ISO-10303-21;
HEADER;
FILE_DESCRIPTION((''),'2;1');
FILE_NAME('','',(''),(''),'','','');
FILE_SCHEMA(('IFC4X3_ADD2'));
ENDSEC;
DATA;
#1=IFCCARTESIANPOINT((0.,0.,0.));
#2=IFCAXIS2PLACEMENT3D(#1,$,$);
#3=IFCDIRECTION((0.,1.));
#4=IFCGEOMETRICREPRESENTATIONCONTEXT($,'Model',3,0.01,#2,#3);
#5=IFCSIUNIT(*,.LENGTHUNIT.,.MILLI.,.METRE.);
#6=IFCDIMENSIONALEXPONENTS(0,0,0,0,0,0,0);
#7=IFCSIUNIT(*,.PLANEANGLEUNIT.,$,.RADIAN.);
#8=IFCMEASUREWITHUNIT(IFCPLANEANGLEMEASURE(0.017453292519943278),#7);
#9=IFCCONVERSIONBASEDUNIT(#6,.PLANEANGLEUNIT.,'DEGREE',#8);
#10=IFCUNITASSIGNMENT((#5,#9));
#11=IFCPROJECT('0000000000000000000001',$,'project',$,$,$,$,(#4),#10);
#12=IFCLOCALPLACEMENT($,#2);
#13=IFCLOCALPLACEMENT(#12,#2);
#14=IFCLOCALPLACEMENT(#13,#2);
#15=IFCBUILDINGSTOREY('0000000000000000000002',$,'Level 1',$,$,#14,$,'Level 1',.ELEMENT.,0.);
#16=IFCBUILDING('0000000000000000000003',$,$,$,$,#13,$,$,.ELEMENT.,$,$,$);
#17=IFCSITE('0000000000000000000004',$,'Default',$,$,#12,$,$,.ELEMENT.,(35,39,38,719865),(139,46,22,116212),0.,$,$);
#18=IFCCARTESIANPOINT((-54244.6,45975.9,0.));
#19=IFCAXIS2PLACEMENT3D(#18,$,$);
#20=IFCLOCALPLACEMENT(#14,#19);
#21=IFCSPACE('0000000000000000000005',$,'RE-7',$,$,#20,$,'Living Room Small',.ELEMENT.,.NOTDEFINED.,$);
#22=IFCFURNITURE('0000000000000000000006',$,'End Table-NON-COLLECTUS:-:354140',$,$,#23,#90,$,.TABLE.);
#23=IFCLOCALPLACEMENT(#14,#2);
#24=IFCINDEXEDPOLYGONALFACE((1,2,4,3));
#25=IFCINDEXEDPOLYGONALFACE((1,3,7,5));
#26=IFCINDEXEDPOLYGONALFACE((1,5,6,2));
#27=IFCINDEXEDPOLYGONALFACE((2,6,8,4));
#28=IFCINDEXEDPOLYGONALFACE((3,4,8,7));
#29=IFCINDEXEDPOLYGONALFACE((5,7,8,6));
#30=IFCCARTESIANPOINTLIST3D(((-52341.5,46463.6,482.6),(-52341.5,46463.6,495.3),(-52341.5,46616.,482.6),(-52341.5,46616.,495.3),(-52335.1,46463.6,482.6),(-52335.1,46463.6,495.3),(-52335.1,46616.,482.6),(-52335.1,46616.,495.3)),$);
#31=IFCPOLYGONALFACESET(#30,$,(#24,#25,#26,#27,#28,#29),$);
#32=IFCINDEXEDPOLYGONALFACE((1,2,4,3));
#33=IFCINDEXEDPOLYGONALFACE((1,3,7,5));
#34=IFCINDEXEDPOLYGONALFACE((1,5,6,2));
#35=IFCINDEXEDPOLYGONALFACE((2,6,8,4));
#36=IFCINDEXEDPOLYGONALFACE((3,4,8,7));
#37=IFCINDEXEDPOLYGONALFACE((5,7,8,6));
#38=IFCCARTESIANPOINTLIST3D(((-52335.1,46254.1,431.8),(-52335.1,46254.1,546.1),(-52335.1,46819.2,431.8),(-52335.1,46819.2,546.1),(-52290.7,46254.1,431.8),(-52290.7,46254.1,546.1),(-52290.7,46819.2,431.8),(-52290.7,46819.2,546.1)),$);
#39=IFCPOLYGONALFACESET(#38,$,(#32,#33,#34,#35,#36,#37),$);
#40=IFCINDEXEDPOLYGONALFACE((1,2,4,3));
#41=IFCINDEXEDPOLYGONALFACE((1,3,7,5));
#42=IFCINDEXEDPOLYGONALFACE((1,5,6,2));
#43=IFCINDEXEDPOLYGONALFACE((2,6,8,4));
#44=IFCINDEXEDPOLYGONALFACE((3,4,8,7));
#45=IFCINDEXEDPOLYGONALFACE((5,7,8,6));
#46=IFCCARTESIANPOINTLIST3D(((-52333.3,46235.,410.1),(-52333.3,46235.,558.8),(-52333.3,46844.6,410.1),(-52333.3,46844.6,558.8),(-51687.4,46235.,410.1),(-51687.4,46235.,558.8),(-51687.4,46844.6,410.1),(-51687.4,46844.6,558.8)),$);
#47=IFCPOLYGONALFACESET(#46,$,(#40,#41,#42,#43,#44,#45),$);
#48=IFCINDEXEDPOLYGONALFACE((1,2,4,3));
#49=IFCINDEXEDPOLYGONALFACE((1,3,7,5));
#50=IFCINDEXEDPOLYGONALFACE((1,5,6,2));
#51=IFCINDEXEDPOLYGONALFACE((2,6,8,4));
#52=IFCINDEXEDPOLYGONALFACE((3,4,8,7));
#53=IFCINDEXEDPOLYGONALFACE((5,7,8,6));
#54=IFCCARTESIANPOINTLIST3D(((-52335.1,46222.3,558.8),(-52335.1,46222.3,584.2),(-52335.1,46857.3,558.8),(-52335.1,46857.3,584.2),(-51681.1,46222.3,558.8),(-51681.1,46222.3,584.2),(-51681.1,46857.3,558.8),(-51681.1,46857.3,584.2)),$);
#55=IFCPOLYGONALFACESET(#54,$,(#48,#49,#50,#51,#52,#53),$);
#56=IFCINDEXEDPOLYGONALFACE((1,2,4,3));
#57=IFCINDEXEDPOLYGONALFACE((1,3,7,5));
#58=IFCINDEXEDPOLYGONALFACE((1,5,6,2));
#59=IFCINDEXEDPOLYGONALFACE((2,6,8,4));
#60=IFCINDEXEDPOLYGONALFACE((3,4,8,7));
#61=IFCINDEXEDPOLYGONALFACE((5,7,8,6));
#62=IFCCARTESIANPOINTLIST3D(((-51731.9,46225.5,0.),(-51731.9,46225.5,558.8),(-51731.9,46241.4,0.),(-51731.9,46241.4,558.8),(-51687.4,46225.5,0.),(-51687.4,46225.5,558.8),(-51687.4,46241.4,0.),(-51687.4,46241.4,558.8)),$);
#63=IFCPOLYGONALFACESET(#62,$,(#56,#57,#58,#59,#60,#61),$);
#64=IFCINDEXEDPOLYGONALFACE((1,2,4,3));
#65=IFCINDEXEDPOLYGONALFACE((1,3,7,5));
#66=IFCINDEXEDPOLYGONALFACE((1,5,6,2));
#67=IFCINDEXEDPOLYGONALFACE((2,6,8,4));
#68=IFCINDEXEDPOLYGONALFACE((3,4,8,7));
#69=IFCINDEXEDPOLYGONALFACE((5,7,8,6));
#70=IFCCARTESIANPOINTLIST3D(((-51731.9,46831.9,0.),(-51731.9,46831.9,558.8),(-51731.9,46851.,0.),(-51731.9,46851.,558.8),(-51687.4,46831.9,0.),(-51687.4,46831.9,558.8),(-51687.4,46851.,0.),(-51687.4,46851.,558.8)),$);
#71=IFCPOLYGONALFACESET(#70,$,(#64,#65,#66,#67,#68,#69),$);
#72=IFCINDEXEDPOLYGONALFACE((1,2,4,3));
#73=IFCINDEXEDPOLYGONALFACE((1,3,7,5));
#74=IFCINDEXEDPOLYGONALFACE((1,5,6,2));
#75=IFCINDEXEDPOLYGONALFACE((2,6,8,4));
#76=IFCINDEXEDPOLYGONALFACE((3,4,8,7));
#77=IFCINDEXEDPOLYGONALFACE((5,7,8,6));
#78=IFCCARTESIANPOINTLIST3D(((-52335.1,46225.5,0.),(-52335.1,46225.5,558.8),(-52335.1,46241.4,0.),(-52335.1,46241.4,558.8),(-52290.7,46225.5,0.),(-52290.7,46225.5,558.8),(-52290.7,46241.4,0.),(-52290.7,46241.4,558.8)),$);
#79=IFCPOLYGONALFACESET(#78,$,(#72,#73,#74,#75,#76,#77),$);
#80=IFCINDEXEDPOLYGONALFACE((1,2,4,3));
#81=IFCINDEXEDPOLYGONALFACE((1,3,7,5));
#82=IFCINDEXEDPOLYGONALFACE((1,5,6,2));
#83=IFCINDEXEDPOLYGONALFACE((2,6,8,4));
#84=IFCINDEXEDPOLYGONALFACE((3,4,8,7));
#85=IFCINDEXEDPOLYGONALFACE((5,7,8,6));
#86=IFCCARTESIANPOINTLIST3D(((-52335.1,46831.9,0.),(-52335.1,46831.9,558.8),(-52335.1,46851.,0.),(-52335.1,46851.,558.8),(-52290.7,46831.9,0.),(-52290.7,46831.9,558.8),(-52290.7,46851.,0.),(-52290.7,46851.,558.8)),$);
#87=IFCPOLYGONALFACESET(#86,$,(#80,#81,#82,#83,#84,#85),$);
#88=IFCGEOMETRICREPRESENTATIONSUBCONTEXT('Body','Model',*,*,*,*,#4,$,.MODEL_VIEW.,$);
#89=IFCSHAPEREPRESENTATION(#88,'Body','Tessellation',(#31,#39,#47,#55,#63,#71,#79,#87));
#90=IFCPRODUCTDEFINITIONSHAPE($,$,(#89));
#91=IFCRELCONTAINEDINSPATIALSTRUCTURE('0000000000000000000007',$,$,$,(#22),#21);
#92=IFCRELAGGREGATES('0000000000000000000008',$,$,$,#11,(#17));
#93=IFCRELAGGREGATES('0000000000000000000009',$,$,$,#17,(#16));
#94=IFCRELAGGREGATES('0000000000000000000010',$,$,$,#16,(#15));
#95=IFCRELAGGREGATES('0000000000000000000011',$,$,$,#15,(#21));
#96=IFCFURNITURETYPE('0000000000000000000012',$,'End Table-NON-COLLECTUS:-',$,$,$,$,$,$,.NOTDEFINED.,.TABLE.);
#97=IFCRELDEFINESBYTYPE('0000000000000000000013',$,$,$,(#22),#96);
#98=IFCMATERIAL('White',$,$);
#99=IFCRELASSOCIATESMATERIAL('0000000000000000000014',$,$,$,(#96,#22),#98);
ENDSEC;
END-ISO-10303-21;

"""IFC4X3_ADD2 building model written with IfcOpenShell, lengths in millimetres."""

from ifc_helpers import new_model, entity, si_unit, converted_unit, direction, frame, frame_2d, origin, origin_2d_with_axis, place, context, subcontext, project, spatial, rectangle, extrude, source, transform, mapped, material, type_object, type_shapes, element, save


model = new_model("IFC4X3_ADD2")

# Units and contexts
model_context = context("Model", 3, precision=0.01, world=origin(), true_north=direction((0.0, 1.0)))
body_context = subcontext(model_context, "Body", "Model", "MODEL_VIEW")
ifc_project = project(units=[si_unit("LENGTHUNIT", "METRE", prefix="MILLI"), converted_unit("PLANEANGLEUNIT", "DEGREE", entity("IfcPlaneAngleMeasure", 0.017453292519943278), si_unit("PLANEANGLEUNIT", "RADIAN"), dimensions=[0, 0, 0, 0, 0, 0, 0])], contexts=[model_context])

# Site, building, storey
site_placement = place(None, origin())
site = spatial("IfcSite", under=ifc_project, at=site_placement, Name="Default", CompositionType="ELEMENT", RefLatitude=(35, 39, 38, 719865), RefLongitude=(139, 46, 22, 116212), RefElevation=0.0)
building_placement = place(site_placement, origin())
building = spatial("IfcBuilding", under=site, at=building_placement, CompositionType="ELEMENT")
storey_placement = place(building_placement, origin())
storey = spatial("IfcBuildingStorey", under=building, at=storey_placement, Name="Level 1", LongName="Level 1", CompositionType="ELEMENT", Elevation=0.0)

# Shared definitions
space_1_placement = place(storey_placement, frame((-54244.6, 45975.9, 0.0)))
space_1 = spatial("IfcSpace", under=storey, at=space_1_placement, Name="RE-7", LongName="Living Room Small", CompositionType="ELEMENT", PredefinedType="NOTDEFINED")

# Furniture
ifc_material_1 = material(Name="White")
furniture_type_1 = type_object("IfcFurnitureType", Name="End Table-NON-COLLECTUS:-", AssemblyPlace="NOTDEFINED", PredefinedType="TABLE", material=ifc_material_1)
shared_shape_1 = source(origin(), body_context, "Body", "SweptSolid", [
    extrude(rectangle(XDim=6.4, YDim=152.4, at=origin_2d_with_axis()), frame((0.0, -657.2, 482.6), z_axis=(0.0, 0.0, 1.0), x_axis=(0.0, 1.0, 0.0)), (0.0, 0.0, 1.0), 12.7),
    extrude(rectangle(XDim=44.4, YDim=565.2, at=origin_2d_with_axis()), frame((3.2, -631.8, 431.8), z_axis=(0.0, 0.0, 1.0), x_axis=(0.0, 1.0, 0.0)), (0.0, 0.0, 1.0), 114.3),
    extrude(rectangle(XDim=609.6, YDim=645.8, at=frame_2d((0.0, 0.0), x_axis=(1.0, 0.0))), frame((0.0, -329.3, 410.1), z_axis=(0.0, 0.0, 1.0), x_axis=(-1.0, 0.0, 0.0)), (0.0, 0.0, 1.0), 148.7),
    extrude(rectangle(XDim=635.0, YDim=654.0, at=frame_2d((0.0, 0.0), x_axis=(1.0, 0.0))), frame((0.0, -327.0, 558.8), z_axis=(0.0, 0.0, 1.0), x_axis=(-1.0, 0.0, 0.0)), (0.0, 0.0, 1.0), 25.4),
    extrude(rectangle(XDim=15.8, YDim=44.4, at=origin_2d_with_axis()), frame((306.4, -28.6, 0.0), z_axis=(0.0, 0.0, 1.0), x_axis=(-1.0, 0.0, 0.0)), (0.0, 0.0, 1.0), 558.8),
    extrude(rectangle(XDim=19.1, YDim=44.5, at=origin_2d_with_axis()), frame((-301.6, -28.6, 0.0), z_axis=(0.0, 0.0, 1.0), x_axis=(-1.0, 0.0, 0.0)), (0.0, 0.0, 1.0), 558.8),
    extrude(rectangle(XDim=15.8, YDim=44.4, at=origin_2d_with_axis()), frame((306.4, -631.8, 0.0), z_axis=(0.0, 0.0, 1.0), x_axis=(-1.0, 0.0, 0.0)), (0.0, 0.0, 1.0), 558.8),
    extrude(rectangle(XDim=19.1, YDim=44.4, at=frame_2d((0.0, 0.0), x_axis=(1.0, 0.0))), frame((-301.6, -631.8, 0.0), z_axis=(0.0, 0.0, 1.0), x_axis=(-1.0, 0.0, 0.0)), (0.0, 0.0, 1.0), 558.8),
])
type_shapes(furniture_type_1, [shared_shape_1])
furniture_1_placement = place(space_1_placement, frame((2563.5, 563.9, 0.0), z_axis=(0.0, 0.0, 1.0), x_axis=(-0.000004, -1.0, 0.0)))
element("IfcFurniture", 1, at=furniture_1_placement, inside=space_1, type_object=furniture_type_1, material=ifc_material_1, Name="End Table-NON-COLLECTUS:-:354140", PredefinedType="TABLE", context=body_context, shape_type="MappedRepresentation", body=[
    mapped(shared_shape_1, transform((0.0, 0.0, 0.0), scale=1.0)),
])

save(model, "model.ifc")
